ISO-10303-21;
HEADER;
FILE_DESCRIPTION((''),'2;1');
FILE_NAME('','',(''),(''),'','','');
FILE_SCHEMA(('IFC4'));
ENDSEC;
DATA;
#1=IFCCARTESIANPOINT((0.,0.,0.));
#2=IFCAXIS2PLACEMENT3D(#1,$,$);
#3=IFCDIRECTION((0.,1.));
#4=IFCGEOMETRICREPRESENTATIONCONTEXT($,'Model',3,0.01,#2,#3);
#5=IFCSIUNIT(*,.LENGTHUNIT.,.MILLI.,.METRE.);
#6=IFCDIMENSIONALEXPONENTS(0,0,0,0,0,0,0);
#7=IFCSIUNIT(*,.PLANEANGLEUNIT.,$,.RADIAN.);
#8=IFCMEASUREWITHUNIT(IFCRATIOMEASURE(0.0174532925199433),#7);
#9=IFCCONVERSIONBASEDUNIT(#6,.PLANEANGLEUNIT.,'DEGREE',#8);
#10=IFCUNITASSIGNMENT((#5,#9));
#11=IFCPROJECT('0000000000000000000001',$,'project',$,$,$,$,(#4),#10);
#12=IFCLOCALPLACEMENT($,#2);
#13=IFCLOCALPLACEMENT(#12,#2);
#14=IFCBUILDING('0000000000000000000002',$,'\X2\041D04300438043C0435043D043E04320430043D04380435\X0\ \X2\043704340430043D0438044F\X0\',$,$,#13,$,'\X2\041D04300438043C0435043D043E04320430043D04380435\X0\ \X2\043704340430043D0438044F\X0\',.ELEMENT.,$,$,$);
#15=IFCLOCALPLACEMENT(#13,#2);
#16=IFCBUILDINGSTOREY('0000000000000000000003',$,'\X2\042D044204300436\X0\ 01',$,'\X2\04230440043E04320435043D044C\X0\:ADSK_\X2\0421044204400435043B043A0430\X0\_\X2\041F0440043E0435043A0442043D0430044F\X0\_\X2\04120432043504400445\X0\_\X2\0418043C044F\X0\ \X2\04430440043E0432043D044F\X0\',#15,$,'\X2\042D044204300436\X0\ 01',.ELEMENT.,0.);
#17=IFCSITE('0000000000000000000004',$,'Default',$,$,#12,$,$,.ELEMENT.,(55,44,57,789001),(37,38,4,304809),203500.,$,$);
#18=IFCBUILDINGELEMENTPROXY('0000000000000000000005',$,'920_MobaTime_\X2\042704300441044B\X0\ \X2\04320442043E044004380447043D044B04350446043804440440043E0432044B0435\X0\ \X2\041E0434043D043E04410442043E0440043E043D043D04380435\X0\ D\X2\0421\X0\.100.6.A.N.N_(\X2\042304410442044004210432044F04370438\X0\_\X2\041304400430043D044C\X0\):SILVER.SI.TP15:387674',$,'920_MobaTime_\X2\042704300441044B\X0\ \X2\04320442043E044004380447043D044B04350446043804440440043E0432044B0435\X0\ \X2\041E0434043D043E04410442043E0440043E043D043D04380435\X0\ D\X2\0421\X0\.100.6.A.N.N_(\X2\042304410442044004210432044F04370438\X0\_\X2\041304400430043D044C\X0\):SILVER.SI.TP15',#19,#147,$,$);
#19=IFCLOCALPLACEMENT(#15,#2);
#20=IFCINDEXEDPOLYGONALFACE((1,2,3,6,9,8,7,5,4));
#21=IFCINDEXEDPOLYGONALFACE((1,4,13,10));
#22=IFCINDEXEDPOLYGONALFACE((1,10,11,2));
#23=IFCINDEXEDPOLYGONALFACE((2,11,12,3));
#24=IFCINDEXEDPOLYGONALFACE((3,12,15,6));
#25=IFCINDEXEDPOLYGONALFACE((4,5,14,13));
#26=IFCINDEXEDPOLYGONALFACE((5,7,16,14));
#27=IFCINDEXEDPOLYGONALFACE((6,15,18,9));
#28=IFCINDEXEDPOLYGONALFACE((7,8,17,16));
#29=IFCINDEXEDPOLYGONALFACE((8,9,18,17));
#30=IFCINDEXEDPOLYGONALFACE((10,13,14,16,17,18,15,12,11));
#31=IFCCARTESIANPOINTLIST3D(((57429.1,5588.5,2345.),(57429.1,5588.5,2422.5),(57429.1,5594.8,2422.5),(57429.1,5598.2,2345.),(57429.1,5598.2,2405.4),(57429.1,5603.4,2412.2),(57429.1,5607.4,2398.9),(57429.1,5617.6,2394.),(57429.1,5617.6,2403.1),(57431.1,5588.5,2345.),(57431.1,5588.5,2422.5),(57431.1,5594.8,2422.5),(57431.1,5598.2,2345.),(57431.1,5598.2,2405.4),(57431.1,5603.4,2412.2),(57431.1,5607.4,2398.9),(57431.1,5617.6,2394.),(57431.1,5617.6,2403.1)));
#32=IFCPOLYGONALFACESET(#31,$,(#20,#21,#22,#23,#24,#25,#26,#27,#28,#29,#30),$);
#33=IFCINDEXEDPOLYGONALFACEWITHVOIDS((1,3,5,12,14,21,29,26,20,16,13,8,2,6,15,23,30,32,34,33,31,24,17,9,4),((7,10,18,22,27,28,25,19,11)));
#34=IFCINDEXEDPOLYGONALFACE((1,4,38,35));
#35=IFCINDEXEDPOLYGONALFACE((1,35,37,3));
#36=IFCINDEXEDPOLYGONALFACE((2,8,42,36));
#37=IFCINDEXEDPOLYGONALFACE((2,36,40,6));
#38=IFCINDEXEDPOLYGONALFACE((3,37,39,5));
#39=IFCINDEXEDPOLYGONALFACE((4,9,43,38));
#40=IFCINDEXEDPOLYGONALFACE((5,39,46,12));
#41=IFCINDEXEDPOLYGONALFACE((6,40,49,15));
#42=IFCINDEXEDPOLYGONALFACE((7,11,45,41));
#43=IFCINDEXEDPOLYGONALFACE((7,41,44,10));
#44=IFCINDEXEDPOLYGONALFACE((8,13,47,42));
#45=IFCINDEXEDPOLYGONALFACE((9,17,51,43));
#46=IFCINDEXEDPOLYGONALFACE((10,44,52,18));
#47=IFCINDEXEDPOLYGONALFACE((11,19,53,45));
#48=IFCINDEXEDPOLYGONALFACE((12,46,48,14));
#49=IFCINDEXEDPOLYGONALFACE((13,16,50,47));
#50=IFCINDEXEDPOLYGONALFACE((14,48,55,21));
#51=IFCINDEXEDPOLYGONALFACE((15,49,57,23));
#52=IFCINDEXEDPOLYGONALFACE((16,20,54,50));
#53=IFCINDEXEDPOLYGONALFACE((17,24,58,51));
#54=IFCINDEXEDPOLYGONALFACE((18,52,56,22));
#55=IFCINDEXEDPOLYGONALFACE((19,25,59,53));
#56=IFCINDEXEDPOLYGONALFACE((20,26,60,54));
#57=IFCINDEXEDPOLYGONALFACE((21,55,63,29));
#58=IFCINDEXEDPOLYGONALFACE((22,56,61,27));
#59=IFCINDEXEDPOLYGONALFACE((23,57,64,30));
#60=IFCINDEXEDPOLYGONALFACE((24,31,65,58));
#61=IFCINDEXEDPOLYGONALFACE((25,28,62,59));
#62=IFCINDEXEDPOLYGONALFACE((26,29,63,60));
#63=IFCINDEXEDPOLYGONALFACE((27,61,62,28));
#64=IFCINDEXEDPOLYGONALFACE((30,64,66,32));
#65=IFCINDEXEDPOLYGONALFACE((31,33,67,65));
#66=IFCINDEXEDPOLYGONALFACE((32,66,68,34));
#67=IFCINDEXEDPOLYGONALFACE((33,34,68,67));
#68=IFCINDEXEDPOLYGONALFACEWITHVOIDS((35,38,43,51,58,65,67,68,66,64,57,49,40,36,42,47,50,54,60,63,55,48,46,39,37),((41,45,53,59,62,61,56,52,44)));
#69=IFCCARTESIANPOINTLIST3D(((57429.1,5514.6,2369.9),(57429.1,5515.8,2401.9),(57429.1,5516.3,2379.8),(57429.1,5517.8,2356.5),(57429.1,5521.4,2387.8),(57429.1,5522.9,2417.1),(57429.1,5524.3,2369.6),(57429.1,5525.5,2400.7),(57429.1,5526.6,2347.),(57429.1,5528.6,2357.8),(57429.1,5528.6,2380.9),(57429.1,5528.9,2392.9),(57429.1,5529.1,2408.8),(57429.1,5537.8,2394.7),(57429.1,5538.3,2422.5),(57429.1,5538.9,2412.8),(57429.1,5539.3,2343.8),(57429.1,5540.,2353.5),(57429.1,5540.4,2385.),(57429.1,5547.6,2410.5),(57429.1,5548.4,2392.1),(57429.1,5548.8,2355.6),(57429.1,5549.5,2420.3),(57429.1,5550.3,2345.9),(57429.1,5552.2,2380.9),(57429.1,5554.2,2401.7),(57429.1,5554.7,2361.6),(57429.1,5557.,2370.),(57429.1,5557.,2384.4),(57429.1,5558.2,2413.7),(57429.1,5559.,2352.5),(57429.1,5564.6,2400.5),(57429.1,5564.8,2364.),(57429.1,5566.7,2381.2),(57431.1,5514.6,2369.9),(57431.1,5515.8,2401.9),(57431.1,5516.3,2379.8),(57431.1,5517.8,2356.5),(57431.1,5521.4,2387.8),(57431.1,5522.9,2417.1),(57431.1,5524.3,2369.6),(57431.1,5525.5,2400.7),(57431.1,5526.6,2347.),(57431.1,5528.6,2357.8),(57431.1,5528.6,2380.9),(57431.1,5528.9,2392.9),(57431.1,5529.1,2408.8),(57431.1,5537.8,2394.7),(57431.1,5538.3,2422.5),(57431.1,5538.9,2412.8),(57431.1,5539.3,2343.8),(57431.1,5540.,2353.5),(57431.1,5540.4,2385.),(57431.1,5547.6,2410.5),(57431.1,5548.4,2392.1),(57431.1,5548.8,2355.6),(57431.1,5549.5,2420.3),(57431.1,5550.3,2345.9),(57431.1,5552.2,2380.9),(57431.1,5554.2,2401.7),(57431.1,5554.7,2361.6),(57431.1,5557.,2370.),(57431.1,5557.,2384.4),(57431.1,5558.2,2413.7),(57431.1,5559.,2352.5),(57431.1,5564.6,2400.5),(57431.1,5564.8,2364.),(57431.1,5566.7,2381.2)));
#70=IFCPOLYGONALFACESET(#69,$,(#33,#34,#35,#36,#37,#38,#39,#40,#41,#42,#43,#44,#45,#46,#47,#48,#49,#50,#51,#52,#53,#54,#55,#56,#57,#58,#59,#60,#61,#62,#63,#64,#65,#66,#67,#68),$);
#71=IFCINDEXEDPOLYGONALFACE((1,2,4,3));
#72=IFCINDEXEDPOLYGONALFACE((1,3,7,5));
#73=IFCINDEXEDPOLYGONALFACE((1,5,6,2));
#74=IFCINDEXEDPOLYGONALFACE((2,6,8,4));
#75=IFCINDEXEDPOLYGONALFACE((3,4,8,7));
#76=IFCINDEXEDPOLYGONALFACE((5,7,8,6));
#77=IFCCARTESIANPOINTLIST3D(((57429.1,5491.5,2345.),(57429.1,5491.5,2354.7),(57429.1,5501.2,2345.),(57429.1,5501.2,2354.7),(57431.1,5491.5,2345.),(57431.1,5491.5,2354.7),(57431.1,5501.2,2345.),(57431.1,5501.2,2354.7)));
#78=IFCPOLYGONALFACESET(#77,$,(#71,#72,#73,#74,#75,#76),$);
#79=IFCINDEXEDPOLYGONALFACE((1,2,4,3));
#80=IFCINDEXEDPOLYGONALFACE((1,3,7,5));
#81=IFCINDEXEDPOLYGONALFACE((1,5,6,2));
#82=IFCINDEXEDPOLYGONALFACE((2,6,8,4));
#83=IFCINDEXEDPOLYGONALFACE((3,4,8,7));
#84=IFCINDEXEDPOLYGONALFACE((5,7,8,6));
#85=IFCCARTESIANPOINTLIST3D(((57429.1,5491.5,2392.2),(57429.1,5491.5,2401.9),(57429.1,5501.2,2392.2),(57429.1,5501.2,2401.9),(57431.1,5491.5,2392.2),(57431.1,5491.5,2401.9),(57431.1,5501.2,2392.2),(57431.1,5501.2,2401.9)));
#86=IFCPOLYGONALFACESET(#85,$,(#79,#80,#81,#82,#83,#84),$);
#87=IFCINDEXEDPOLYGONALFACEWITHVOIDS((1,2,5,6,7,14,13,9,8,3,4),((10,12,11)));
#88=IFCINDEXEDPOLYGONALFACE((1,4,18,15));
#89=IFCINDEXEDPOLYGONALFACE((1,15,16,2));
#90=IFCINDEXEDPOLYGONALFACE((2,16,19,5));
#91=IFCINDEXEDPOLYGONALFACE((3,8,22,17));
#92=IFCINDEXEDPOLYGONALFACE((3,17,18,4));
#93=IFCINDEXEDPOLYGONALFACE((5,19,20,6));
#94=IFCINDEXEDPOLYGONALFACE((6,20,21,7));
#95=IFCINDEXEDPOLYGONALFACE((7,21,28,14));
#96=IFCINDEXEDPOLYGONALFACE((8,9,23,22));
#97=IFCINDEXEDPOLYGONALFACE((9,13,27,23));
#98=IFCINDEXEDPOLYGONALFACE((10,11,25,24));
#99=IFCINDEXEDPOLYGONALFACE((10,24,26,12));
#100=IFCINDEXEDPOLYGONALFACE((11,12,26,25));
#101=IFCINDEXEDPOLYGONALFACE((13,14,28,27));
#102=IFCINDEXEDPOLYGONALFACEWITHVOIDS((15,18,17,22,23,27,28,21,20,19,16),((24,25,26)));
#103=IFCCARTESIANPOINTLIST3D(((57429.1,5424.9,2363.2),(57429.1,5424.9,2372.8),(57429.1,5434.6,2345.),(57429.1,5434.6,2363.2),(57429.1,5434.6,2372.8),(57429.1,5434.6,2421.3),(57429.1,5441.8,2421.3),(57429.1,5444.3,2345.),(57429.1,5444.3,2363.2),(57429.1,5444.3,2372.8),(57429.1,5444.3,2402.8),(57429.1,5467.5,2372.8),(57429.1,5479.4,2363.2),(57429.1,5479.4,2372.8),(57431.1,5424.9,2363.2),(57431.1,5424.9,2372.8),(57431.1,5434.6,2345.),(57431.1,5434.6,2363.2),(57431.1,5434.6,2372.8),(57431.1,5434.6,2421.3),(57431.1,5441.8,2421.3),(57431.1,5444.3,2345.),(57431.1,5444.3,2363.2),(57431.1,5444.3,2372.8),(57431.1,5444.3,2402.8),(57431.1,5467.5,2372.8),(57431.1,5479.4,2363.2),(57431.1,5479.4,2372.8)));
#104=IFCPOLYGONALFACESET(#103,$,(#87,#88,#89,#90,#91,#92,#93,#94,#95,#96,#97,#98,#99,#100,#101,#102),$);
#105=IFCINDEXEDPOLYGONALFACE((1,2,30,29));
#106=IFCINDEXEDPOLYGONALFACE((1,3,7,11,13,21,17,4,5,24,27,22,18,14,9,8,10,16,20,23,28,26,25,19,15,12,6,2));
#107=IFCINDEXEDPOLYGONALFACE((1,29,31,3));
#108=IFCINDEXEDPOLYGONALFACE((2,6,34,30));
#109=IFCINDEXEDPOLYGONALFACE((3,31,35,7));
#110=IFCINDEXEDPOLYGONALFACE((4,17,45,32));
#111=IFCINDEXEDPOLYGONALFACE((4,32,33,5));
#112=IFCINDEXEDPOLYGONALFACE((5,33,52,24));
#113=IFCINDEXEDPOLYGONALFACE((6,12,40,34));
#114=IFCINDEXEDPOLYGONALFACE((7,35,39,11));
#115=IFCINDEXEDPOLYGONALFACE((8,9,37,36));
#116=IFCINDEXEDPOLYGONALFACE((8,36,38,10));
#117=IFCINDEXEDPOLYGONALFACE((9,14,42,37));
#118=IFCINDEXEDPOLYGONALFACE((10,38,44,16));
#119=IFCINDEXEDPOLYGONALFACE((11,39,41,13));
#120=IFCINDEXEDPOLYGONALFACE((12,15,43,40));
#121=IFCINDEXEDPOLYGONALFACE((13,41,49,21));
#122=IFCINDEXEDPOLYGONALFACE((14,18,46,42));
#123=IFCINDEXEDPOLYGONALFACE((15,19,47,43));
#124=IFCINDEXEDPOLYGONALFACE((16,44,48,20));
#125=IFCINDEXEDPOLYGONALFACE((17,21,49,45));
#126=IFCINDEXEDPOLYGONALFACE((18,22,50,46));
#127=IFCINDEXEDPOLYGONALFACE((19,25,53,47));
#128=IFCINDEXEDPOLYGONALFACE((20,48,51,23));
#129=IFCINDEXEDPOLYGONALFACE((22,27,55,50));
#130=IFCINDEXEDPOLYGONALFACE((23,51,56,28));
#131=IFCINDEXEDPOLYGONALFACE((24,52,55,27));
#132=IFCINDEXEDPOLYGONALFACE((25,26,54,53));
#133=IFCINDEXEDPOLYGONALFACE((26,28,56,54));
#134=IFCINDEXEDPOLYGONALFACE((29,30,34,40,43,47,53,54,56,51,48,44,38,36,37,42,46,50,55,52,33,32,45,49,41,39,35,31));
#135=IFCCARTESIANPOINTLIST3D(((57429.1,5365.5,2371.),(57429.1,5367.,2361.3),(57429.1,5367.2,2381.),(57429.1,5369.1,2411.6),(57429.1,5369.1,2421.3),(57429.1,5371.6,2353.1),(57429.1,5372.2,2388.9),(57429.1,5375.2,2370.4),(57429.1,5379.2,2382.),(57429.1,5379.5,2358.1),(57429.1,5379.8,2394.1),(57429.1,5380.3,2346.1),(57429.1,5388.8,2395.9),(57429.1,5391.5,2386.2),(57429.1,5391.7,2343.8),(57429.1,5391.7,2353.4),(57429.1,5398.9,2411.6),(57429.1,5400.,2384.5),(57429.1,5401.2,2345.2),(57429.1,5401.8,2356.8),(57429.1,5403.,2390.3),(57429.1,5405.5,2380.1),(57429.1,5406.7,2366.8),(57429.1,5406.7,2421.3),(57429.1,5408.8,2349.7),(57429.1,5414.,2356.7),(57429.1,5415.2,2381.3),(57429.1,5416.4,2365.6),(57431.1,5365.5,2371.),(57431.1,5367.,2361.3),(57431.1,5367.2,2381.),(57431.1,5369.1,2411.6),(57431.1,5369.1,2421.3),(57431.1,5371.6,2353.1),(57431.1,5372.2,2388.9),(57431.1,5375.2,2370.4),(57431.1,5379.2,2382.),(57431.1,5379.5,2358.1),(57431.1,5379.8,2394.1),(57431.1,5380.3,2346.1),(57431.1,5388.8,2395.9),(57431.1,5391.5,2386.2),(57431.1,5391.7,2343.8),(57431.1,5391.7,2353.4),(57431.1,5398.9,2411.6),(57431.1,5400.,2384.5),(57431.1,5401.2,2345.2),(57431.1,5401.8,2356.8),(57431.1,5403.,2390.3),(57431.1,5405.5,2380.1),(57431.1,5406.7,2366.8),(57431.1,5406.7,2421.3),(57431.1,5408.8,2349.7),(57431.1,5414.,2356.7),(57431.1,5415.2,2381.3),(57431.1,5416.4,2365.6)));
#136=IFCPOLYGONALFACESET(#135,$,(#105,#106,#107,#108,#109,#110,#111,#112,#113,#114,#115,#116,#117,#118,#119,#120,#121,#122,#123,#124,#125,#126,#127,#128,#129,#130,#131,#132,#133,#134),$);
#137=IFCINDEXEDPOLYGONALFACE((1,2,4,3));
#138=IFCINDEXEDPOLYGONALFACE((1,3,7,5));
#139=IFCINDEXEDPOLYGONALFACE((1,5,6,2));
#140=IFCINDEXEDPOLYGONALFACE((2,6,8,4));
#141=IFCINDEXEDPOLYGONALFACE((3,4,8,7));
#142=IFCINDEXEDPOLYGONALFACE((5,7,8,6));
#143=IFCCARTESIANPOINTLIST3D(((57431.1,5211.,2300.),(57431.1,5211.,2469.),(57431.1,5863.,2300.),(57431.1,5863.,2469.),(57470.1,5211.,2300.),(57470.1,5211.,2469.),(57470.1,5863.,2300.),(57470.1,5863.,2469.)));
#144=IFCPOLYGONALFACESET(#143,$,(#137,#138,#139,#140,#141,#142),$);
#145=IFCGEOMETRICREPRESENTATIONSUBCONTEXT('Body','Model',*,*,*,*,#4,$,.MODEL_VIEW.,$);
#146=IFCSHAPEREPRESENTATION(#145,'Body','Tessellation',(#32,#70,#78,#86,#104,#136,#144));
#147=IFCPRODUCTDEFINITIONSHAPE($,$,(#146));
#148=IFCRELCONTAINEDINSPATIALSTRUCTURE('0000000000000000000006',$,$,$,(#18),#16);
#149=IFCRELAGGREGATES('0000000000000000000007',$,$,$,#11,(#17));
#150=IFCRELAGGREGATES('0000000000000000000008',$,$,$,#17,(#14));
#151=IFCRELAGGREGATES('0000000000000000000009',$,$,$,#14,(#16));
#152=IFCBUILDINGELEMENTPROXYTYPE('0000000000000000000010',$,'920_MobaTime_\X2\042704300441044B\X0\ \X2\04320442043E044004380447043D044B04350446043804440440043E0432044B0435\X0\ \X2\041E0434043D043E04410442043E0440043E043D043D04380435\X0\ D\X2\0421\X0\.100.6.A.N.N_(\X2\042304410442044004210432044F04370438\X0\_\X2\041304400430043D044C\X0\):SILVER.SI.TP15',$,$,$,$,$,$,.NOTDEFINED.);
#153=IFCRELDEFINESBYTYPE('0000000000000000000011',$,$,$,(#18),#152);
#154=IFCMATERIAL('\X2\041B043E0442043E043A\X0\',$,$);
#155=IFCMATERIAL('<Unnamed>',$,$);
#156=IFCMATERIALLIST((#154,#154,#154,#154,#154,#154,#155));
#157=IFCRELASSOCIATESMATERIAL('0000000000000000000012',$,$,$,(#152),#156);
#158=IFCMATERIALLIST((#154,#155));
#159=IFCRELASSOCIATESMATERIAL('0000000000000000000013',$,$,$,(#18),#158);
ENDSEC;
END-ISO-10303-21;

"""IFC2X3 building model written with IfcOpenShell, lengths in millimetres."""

from ifc_helpers import new_model, entity, si_unit, converted_unit, direction, frame, origin, origin_2d_with_axis, place, context, subcontext, project, spatial, polyline, rectangle, outline, extrude, source, transform, mapped, material, material_list, type_object, type_shapes, element, save


model = new_model("IFC2X3")

# Units and contexts
model_context = context("Model", 3, precision=0.01, world=origin(), true_north=direction((0.0, 1.0)))
body_context = subcontext(model_context, "Body", "Model", "MODEL_VIEW")
ifc_project = project(units=[si_unit("LENGTHUNIT", "METRE", prefix="MILLI"), converted_unit("PLANEANGLEUNIT", "DEGREE", entity("IfcRatioMeasure", 0.0174532925199433), si_unit("PLANEANGLEUNIT", "RADIAN"), dimensions=[0, 0, 0, 0, 0, 0, 0])], contexts=[model_context])

# Site, building, storey
site_placement = place(None, origin())
site = spatial("IfcSite", under=ifc_project, at=site_placement, Name="Default", CompositionType="ELEMENT", RefLatitude=(55, 44, 57, 789001), RefLongitude=(37, 38, 4, 304809), RefElevation=203500.0)
building_placement = place(site_placement, origin())
building = spatial("IfcBuilding", under=site, at=building_placement, Name="Наименование здания", LongName="Наименование здания", CompositionType="ELEMENT")
storey_placement = place(building_placement, origin())
storey = spatial("IfcBuildingStorey", under=building, at=storey_placement, Name="Этаж 01", ObjectType="Уровень:ADSK_Стрелка_Проектная_Вверх_Имя уровня", LongName="Этаж 01", CompositionType="ELEMENT", Elevation=0.0)

# Building element proxy
ifc_material_1 = material(Name="Лоток")
ifc_material_2 = material(Name="<Unnamed>")
ifc_material_list_1 = material_list([ifc_material_1, ifc_material_1, ifc_material_1, ifc_material_1, ifc_material_1, ifc_material_1, ifc_material_2])
building_element_proxy_type = type_object("IfcBuildingElementProxyType", Name="920_MobaTime_Часы вторичныецифровые Односторонние DС.100.6.A.N.N_(УстрСвязи_Грань):SILVER.SI.TP15", PredefinedType="NOTDEFINED", material=ifc_material_list_1)
shared_shape = source(origin(), body_context, "Body", "SweptSolid", [
    extrude(outline(polyline([(-49.3, -13.1), (28.2, -13.1), (28.2, -6.8), (17.9, 1.8), (8.8, 16.0), (-0.3, 16.0), (4.6, 5.8), (11.1, -3.4), (-49.3, -3.4), (-49.3, -13.1)])), frame((-64.6, 9.8, 39.0), z_axis=(0.0, 0.0, 1.0), x_axis=(0.0, 1.0, 0.0)), (0.0, 0.0, 1.0), 2.0),
    extrude(outline(polyline([(2.2, -27.6), (19.0, -27.6), (30.5, -16.1), (33.3, -4.9), (31.0, 5.8), (21.8, 17.2), (5.2, 27.3), (-11.1, 33.0), (-24.0, 32.7), (-33.6, 27.6), (-40.3, 18.6), (-42.8, 5.7), (-38.0, -6.3), (-27.2, -14.9), (-17.5, -17.7), (-8.2, -16.4), (-0.3, -11.9), (5.1, -4.5), (7.3, 6.2), (4.0, 17.2), (18.4, 7.3), (23.6, -2.4), (22.0, -11.4), (14.2, -18.4), (5.3, -18.3), (2.2, -27.6)]), holes=[polyline([(-9.0, 23.3), (-1.3, 14.3), (-2.5, 2.0), (-11.4, -7.0), (-23.4, -6.0), (-32.2, 2.9), (-31.2, 15.1), (-25.6, 22.1), (-17.5, 24.9), (-9.0, 23.3)])]), frame((-2.7, 3.6, 39.0), z_axis=(0.0, 0.0, 1.0), x_axis=(-0.427649, 0.903945, 0.0)), (0.0, 0.0, 1.0), 2.0),
    extrude(rectangle(XDim=9.7, YDim=9.7, at=origin_2d_with_axis()), frame((40.6, -34.7, 39.0)), (0.0, 0.0, 1.0), 2.0),
    extrude(rectangle(XDim=9.7, YDim=9.7, at=origin_2d_with_axis()), frame((40.6, 12.6, 39.0)), (0.0, 0.0, 1.0), 2.0),
    extrude(outline(polyline([(-0.9, -28.1), (8.8, -28.1), (8.8, -9.9), (18.5, -9.9), (18.5, -0.2), (8.8, -0.2), (8.8, 48.3), (1.5, 48.3), (-36.0, -0.2), (-36.0, -9.9), (-0.9, -9.9), (-0.9, -28.1)]), holes=[polyline([(-0.9, -0.2), (-24.1, -0.2), (-0.9, 29.7), (-0.9, -0.2)])]), frame((93.6, -11.4, 39.0)), (0.0, 0.0, 1.0), 2.0),
    extrude(outline(polyline([(3.3, -28.3), (12.5, -28.3), (20.5, -25.0), (26.8, -18.9), (30.7, -10.0), (31.4, 1.6), (26.9, 11.8), (20.1, 18.4), (11.1, 22.3), (1.0, 23.3), (-7.9, 20.4), (-14.9, 14.5), (-18.9, 6.2), (-17.1, -9.0), (-36.7, 0.5), (-29.1, 29.2), (-38.5, 31.7), (-48.1, -4.6), (-11.6, -23.1), (-8.0, -14.0), (-10.8, -7.6), (-10.2, 1.1), (-3.0, 11.8), (9.2, 12.8), (20.0, 5.5), (21.4, -7.5), (15.5, -16.4), (4.6, -18.6), (3.3, -28.3)])), frame((147.1, -8.5, 39.0), z_axis=(0.0, 0.0, 1.0), x_axis=(0.256974, -0.966418, 0.0)), (0.0, 0.0, 1.0), 2.0),
    extrude(rectangle(XDim=652.0, YDim=169.0, at=origin_2d_with_axis()), frame((0.0, 0.0, 0.0), z_axis=(0.0, 0.0, 1.0), x_axis=(-1.0, 0.0, 0.0)), (0.0, 0.0, 1.0), 39.0),
])
type_shapes(building_element_proxy_type, [shared_shape])
ifc_material_list_2 = material_list([ifc_material_1, ifc_material_2])
for number, where, z_axis, x_axis, name in (
    (1, (57470.1, 5537.0, 2384.5), (-1.0, 0.0, 0.0), (0.0, -1.0, 0.0), "920_MobaTime_Часы вторичныецифровые Односторонние DС.100.6.A.N.N_(УстрСвязи_Грань):SILVER.SI.TP15:387674"),
):
    element("IfcBuildingElementProxy", number, at=place(storey_placement, frame(where, z_axis=z_axis, x_axis=x_axis)), inside=storey, type_object=building_element_proxy_type, material=ifc_material_list_2, Name=name, ObjectType="920_MobaTime_Часы вторичныецифровые Односторонние DС.100.6.A.N.N_(УстрСвязи_Грань):SILVER.SI.TP15", context=body_context, shape_type="MappedRepresentation", body=[
        mapped(shared_shape, transform((0.0, 0.0, 0.0), scale=1.0)),
    ])

save(model, "model.ifc")
